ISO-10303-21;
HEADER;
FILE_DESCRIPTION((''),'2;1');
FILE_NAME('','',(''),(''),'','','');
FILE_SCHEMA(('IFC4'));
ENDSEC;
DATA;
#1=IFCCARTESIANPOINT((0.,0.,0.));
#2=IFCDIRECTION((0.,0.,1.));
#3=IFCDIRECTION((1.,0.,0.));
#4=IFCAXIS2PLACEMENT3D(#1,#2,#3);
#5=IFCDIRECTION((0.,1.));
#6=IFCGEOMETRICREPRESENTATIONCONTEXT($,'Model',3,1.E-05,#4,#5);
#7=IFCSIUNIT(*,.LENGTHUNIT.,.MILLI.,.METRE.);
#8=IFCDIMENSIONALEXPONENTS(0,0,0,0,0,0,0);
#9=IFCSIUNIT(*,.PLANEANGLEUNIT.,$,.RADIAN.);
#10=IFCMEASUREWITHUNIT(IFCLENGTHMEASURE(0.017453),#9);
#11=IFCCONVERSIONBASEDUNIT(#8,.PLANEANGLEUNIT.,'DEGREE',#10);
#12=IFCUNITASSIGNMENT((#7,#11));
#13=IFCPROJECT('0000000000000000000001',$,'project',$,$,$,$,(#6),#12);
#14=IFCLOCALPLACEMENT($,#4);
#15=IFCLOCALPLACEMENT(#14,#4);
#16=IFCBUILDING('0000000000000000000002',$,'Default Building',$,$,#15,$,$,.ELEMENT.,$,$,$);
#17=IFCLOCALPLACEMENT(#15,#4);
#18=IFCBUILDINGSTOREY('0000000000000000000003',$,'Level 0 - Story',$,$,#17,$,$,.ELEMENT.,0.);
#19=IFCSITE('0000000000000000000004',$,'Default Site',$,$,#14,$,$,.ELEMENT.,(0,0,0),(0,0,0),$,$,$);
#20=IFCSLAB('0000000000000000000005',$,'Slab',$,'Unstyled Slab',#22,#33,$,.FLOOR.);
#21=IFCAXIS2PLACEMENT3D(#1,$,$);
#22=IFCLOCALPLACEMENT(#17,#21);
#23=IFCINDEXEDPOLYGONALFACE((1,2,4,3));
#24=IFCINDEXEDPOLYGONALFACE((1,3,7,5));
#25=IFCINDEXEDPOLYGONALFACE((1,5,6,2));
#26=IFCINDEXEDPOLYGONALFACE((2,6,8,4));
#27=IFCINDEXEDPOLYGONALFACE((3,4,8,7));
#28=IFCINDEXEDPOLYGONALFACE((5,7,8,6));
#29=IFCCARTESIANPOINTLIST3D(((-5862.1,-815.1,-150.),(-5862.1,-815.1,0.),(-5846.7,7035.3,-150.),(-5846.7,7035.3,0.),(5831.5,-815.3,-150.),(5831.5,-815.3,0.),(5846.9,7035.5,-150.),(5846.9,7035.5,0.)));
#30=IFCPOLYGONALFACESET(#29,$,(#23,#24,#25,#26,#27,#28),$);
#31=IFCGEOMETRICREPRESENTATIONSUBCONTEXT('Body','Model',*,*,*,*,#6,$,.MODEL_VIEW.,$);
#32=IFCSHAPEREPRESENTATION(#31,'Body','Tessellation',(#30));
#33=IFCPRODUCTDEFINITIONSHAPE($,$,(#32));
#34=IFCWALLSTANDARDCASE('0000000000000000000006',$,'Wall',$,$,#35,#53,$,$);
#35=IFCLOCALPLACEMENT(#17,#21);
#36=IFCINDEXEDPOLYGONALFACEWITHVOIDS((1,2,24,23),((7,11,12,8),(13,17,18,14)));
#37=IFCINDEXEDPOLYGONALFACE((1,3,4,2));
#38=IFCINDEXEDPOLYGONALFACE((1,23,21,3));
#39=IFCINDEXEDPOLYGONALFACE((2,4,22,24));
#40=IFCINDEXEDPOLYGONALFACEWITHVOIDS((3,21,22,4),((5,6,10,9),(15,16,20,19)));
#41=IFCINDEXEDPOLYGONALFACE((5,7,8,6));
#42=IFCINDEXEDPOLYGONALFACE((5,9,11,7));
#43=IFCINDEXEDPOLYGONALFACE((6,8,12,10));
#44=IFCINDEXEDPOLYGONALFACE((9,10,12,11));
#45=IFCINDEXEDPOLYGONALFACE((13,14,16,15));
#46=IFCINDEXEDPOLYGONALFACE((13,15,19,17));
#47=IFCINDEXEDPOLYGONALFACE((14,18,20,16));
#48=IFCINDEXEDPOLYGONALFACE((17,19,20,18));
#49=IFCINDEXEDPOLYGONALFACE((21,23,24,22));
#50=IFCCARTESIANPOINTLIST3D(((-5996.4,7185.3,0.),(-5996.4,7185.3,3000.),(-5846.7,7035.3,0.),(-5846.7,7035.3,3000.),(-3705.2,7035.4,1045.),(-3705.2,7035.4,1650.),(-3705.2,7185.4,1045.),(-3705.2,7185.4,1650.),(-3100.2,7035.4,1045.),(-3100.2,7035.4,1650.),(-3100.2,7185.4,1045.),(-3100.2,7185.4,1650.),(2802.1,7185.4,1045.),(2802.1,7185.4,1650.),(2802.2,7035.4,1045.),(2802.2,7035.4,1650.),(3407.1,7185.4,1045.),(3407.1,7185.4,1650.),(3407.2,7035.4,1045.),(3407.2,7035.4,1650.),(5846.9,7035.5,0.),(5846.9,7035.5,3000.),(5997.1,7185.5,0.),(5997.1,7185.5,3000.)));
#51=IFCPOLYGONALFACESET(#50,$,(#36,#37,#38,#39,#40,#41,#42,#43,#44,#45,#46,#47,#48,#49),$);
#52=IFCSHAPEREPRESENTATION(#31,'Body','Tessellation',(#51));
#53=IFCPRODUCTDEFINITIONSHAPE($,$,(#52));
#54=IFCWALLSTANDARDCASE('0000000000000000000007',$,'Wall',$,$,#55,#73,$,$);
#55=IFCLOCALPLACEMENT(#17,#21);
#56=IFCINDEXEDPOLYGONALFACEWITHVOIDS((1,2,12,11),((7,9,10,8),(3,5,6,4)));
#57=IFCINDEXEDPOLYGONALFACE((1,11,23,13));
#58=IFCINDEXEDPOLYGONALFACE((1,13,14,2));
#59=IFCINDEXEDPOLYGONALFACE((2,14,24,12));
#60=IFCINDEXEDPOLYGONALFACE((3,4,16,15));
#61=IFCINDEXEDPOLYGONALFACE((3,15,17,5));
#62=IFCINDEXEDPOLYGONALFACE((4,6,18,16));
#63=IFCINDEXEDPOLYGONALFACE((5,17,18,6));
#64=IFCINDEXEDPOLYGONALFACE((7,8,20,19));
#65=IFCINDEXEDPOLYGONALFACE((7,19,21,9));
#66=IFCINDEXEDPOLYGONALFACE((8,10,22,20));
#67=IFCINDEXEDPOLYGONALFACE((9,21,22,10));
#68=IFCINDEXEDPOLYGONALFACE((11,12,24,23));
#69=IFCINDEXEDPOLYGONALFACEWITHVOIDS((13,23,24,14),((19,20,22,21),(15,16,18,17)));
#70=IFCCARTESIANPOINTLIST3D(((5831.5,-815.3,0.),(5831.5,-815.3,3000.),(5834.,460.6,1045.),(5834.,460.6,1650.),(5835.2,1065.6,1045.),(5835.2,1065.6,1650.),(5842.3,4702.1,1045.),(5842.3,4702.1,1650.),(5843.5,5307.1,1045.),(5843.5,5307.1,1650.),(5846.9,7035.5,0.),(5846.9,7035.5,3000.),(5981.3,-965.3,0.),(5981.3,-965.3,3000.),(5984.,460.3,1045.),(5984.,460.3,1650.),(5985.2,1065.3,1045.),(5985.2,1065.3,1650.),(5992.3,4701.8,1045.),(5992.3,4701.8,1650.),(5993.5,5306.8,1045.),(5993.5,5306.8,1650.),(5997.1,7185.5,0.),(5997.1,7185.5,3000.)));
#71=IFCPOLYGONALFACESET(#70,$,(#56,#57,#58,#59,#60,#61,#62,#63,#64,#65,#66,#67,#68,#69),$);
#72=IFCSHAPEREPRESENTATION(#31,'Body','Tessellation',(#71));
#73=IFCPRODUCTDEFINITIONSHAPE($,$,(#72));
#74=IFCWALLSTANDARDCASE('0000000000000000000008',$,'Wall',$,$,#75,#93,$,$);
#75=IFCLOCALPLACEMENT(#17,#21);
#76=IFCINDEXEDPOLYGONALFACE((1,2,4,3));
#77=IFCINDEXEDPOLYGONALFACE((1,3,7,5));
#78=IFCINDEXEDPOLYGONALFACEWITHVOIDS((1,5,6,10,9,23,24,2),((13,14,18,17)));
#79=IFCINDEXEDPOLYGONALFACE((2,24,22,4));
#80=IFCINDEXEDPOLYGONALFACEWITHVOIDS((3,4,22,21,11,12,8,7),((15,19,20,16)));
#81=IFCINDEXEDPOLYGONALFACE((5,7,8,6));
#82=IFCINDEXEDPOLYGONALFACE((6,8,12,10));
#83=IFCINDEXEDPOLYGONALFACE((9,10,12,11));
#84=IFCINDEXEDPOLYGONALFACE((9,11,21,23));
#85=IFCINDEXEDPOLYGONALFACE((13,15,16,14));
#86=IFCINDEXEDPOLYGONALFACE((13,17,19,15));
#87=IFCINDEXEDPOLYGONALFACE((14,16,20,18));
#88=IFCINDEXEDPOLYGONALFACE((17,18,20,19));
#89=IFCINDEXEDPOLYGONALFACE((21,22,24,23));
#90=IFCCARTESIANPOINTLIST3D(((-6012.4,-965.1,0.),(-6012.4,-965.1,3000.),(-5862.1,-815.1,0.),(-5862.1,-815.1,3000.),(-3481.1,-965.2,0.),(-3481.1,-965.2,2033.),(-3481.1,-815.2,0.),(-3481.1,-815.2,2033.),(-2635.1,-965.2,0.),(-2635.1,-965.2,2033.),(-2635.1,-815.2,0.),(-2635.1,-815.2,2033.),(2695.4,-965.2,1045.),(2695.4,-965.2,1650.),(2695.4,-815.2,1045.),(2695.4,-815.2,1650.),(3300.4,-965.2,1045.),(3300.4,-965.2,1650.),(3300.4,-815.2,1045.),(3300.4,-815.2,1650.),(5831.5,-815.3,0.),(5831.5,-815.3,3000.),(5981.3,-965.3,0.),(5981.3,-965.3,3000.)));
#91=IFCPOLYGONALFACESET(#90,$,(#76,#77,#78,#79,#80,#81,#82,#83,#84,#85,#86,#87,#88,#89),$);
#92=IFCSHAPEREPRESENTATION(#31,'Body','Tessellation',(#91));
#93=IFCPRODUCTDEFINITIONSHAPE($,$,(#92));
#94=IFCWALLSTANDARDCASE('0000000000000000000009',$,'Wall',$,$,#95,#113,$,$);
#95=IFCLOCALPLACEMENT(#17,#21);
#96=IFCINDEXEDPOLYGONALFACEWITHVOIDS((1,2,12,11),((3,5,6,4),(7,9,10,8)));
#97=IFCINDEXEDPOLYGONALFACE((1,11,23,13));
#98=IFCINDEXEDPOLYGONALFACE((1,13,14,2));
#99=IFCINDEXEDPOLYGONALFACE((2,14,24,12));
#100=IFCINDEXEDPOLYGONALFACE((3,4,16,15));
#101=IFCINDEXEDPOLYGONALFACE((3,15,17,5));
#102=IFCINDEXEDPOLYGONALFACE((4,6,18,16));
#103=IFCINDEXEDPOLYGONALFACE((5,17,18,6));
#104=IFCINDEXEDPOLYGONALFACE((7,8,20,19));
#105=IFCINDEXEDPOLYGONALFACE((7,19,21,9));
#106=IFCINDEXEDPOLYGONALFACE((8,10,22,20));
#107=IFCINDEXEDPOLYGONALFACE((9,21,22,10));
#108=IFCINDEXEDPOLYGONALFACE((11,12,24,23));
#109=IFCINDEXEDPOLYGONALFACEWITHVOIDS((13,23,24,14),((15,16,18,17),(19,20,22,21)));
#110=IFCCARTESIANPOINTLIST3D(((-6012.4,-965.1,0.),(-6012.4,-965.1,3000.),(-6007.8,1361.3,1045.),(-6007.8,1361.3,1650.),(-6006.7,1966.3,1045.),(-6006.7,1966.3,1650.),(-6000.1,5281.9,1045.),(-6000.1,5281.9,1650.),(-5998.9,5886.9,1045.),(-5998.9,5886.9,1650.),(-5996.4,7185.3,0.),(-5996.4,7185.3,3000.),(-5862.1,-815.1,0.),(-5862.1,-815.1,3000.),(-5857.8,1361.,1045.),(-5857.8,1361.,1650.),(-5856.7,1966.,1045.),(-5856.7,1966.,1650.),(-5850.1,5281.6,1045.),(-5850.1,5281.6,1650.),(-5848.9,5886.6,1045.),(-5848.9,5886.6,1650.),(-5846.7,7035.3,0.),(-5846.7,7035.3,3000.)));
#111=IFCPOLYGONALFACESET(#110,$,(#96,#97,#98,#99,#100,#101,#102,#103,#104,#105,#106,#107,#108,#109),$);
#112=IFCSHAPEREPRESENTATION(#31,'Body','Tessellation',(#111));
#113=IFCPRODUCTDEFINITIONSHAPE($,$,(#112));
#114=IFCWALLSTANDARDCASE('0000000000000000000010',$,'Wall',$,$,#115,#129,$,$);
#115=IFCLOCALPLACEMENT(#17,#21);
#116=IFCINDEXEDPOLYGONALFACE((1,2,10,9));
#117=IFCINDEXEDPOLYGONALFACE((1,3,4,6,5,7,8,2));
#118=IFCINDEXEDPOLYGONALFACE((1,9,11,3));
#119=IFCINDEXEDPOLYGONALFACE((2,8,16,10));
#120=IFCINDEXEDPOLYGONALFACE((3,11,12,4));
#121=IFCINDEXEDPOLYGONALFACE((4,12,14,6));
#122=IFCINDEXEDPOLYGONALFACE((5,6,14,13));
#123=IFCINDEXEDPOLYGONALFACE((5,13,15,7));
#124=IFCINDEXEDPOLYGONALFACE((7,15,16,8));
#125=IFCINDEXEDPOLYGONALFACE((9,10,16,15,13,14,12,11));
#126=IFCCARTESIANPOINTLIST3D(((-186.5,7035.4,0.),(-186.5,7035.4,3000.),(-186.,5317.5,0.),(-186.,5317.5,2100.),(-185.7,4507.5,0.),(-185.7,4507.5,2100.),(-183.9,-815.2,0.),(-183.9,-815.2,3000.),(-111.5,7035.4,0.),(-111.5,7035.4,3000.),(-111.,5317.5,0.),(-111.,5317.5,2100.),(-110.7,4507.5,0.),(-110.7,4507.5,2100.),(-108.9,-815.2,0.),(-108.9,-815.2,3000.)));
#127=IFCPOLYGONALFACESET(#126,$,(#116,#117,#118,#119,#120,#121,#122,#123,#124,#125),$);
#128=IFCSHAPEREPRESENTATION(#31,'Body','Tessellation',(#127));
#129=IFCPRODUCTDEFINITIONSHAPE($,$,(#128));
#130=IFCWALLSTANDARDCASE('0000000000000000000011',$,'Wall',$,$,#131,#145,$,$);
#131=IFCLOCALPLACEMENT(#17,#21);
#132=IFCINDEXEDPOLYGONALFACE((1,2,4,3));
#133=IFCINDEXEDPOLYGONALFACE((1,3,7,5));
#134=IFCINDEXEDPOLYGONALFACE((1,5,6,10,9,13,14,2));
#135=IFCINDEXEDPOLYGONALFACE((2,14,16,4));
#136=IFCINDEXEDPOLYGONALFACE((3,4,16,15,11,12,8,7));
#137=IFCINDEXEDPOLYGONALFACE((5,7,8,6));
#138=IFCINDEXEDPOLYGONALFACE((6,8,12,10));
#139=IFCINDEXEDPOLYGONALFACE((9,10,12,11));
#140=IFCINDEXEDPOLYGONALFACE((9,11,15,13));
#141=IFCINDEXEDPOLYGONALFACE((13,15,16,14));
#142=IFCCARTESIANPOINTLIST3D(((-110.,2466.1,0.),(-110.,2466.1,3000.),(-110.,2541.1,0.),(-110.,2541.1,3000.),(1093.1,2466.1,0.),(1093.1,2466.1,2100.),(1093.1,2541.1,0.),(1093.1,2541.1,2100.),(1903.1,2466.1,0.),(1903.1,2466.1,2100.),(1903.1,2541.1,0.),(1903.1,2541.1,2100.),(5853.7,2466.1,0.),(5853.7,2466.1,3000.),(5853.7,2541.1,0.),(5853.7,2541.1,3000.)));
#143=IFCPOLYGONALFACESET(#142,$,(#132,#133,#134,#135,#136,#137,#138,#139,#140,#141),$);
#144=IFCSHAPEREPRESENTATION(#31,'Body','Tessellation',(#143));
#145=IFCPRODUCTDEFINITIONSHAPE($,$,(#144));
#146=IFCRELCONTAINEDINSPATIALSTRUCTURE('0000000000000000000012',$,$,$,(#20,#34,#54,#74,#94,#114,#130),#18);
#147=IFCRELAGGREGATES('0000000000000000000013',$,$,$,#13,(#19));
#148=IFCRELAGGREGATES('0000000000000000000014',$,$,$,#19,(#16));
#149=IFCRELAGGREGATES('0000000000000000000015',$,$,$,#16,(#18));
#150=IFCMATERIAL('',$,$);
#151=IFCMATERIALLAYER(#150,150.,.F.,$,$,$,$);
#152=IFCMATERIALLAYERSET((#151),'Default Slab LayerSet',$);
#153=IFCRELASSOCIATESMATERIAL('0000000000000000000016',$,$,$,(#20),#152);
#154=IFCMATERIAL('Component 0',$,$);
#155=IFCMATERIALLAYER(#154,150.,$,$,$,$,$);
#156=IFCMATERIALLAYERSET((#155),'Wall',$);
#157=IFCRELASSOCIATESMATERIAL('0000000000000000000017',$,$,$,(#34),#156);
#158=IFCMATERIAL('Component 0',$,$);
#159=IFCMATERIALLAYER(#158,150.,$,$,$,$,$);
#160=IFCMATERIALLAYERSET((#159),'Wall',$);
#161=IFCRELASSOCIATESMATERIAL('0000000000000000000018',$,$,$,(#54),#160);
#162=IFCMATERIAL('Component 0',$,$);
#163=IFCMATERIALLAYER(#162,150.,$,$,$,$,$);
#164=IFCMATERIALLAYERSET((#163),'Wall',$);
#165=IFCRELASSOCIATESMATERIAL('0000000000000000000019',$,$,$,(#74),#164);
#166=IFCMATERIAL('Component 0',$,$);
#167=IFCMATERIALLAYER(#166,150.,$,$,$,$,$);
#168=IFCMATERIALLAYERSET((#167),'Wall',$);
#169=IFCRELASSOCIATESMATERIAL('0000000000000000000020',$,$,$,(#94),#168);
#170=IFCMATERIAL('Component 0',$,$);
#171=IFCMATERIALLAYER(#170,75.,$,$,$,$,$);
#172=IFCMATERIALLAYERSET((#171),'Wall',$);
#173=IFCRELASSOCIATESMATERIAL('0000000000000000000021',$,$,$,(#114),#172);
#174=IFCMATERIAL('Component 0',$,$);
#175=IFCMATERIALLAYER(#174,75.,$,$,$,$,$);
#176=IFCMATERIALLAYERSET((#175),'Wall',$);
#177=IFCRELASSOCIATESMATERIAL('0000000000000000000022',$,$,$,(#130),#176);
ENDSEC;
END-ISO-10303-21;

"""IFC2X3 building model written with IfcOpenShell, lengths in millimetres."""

from ifc_helpers import new_model, entity, si_unit, converted_unit, direction, frame, origin_with_axes, place, context, subcontext, project, spatial, polyline, outline, extrude, material, layer, layer_set, layer_usage, element, save


model = new_model("IFC2X3")

# Units and contexts
model_context = context("Model", 3, precision=1e-05, world=origin_with_axes(), true_north=direction((0.0, 1.0)))
body_context = subcontext(model_context, "Body", "Model", "MODEL_VIEW")
ifc_project = project(units=[si_unit("LENGTHUNIT", "METRE", prefix="MILLI"), converted_unit("PLANEANGLEUNIT", "DEGREE", entity("IfcLengthMeasure", 0.017453), si_unit("PLANEANGLEUNIT", "RADIAN"), dimensions=[0, 0, 0, 0, 0, 0, 0])], contexts=[model_context])

# Site, building, storey
site_placement = place(None, origin_with_axes())
site = spatial("IfcSite", under=ifc_project, at=site_placement, Name="Default Site", CompositionType="ELEMENT", RefLatitude=(0, 0, 0), RefLongitude=(0, 0, 0))
building_placement = place(site_placement, origin_with_axes())
building = spatial("IfcBuilding", under=site, at=building_placement, Name="Default Building", CompositionType="ELEMENT")
storey_placement = place(building_placement, origin_with_axes())
storey = spatial("IfcBuildingStorey", under=building, at=storey_placement, Name="Level 0 - Story", CompositionType="ELEMENT", Elevation=0.0)

# Slab
ifc_material_1 = material(Name="")
ifc_layer_1 = layer(ifc_material_1, 150.0, ventilated=False)
ifc_layer_set_1 = layer_set([ifc_layer_1], Name="Default Slab LayerSet")
ifc_layer_usage_1 = layer_usage(ifc_layer_set_1, "AXIS3", "NEGATIVE", 0.0)
slab_placement = place(storey_placement, origin_with_axes())
element("IfcSlab", 1, at=slab_placement, inside=storey, material=ifc_layer_usage_1, Name="Slab", ObjectType="Unstyled Slab", PredefinedType="FLOOR", context=body_context, shape_type="SweptSolid", body=[
    extrude(outline(polyline([(-15.5, 7850.5), (11678.1, 7850.8), (11693.5, 0.0), (0.0, 0.0), (-15.5, 7850.5)])), frame((-5846.7, 7035.3, -150.0), z_axis=(0.0, 0.0, -1.0), x_axis=(1.0, 0.000012, 0.0)), (0.0, 0.0, -1.0), 150.0),
])

# Walls, openings
ifc_material_2 = material(Name="Component 0")
ifc_layer_2 = layer(ifc_material_2, 150.0)
ifc_layer_set_2 = layer_set([ifc_layer_2], Name="Wall")
ifc_layer_usage_2 = layer_usage(ifc_layer_set_2, "AXIS2", "POSITIVE", -75.0)
wall_1_placement = place(storey_placement, frame((-5921.5, 7110.3, 0.0), z_axis=(0.0, 0.0, 1.0), x_axis=(1.0, 0.000012, 0.0)))
wall_1 = element("IfcWallStandardCase", 2, at=wall_1_placement, inside=storey, material=ifc_layer_usage_2, Name="Wall", context=body_context, shape_type="SweptSolid", body=[
    extrude(outline(polyline([(74.9, -75.0), (-74.9, 75.0), (11918.7, 75.0), (11768.4, -75.0), (74.9, -75.0)])), origin_with_axes(), (0.0, 0.0, 1.0), 3000.0),
])
opening_1_placement = place(wall_1_placement, frame((2216.3, 0.0, 1045.0), z_axis=(0.0, 1.0, 0.0), x_axis=(0.0, 0.0, 1.0)))
element("IfcOpeningElement", 3, at=opening_1_placement, cuts=wall_1, context=body_context, shape_type="SweptSolid", body=[
    extrude(outline(polyline([(0.0, 0.0), (605.0, 0.0), (605.0, 605.0), (0.0, 605.0), (0.0, 0.0)])), frame((0.0, 0.0, 150.0), z_axis=(0.0, 0.0, 1.0), x_axis=(1.0, 0.0, 0.0)), (0.0, 0.0, -1.0), 300.0),
])
opening_2_placement = place(wall_1_placement, frame((8723.7, 0.0, 1045.0), z_axis=(0.0, 1.0, 0.0), x_axis=(0.0, 0.0, 1.0)))
element("IfcOpeningElement", 4, at=opening_2_placement, cuts=wall_1, context=body_context, shape_type="SweptSolid", body=[
    extrude(outline(polyline([(0.0, 0.0), (605.0, 0.0), (605.0, 605.0), (0.0, 605.0), (0.0, 0.0)])), frame((0.0, 0.0, 150.0), z_axis=(0.0, 0.0, 1.0), x_axis=(1.0, 0.0, 0.0)), (0.0, 0.0, -1.0), 300.0),
])
ifc_material_3 = material(Name="Component 0")
ifc_layer_3 = layer(ifc_material_3, 150.0)
ifc_layer_set_3 = layer_set([ifc_layer_3], Name="Wall")
ifc_layer_usage_3 = layer_usage(ifc_layer_set_3, "AXIS2", "POSITIVE", -75.0)
wall_2_placement = place(storey_placement, frame((5922.0, 7110.5, 0.0), z_axis=(0.0, 0.0, 1.0), x_axis=(-0.00195, -0.999998, 0.0)))
wall_2 = element("IfcWallStandardCase", 5, at=wall_2_placement, inside=storey, material=ifc_layer_usage_3, Name="Wall", context=body_context, shape_type="SweptSolid", body=[
    extrude(outline(polyline([(75.1, -75.0), (-75.1, 75.0), (8075.6, 75.0), (7925.9, -75.0), (75.1, -75.0)])), origin_with_axes(), (0.0, 0.0, 1.0), 3000.0),
])
opening_3_placement = place(wall_2_placement, frame((1803.5, 0.0, 1045.0), z_axis=(0.0, 1.0, 0.0), x_axis=(0.0, 0.0, 1.0)))
element("IfcOpeningElement", 6, at=opening_3_placement, cuts=wall_2, context=body_context, shape_type="SweptSolid", body=[
    extrude(outline(polyline([(0.0, 0.0), (605.0, 0.0), (605.0, 605.0), (0.0, 605.0), (0.0, 0.0)])), frame((0.0, 0.0, 150.0), z_axis=(0.0, 0.0, 1.0), x_axis=(1.0, 0.0, 0.0)), (0.0, 0.0, -1.0), 300.0),
])
opening_4_placement = place(wall_2_placement, frame((6045.0, 0.0, 1045.0), z_axis=(0.0, 1.0, 0.0), x_axis=(0.0, 0.0, 1.0)))
element("IfcOpeningElement", 7, at=opening_4_placement, cuts=wall_2, context=body_context, shape_type="SweptSolid", body=[
    extrude(outline(polyline([(0.0, 0.0), (605.0, 0.0), (605.0, 605.0), (0.0, 605.0), (0.0, 0.0)])), frame((0.0, 0.0, 150.0), z_axis=(0.0, 0.0, 1.0), x_axis=(1.0, 0.0, 0.0)), (0.0, 0.0, -1.0), 300.0),
])
ifc_material_4 = material(Name="Component 0")
ifc_layer_4 = layer(ifc_material_4, 150.0)
ifc_layer_set_4 = layer_set([ifc_layer_4], Name="Wall")
ifc_layer_usage_4 = layer_usage(ifc_layer_set_4, "AXIS2", "POSITIVE", -75.0)
wall_3_placement = place(storey_placement, frame((5906.4, -890.3, 0.0), z_axis=(0.0, 0.0, 1.0), x_axis=(-1.0, 0.000012, 0.0)))
wall_3 = element("IfcWallStandardCase", 8, at=wall_3_placement, inside=storey, material=ifc_layer_usage_4, Name="Wall", context=body_context, shape_type="SweptSolid", body=[
    extrude(outline(polyline([(74.9, -75.0), (-74.9, 75.0), (11918.8, 75.0), (11768.5, -75.0), (74.9, -75.0)])), origin_with_axes(), (0.0, 0.0, 1.0), 3000.0),
])
opening_5_placement = place(wall_3_placement, frame((2606.0, 0.0, 1045.0), z_axis=(0.0, 1.0, 0.0), x_axis=(0.0, 0.0, 1.0)))
element("IfcOpeningElement", 9, at=opening_5_placement, cuts=wall_3, context=body_context, shape_type="SweptSolid", body=[
    extrude(outline(polyline([(0.0, 0.0), (605.0, 0.0), (605.0, 605.0), (0.0, 605.0), (0.0, 0.0)])), frame((0.0, 0.0, 150.0), z_axis=(0.0, 0.0, 1.0), x_axis=(1.0, 0.0, 0.0)), (0.0, 0.0, -1.0), 300.0),
])
opening_6_placement = place(wall_3_placement, frame((8541.5, 0.0, 0.0), z_axis=(0.0, 1.0, 0.0), x_axis=(0.0, 0.0, 1.0)))
element("IfcOpeningElement", 10, at=opening_6_placement, cuts=wall_3, context=body_context, shape_type="SweptSolid", body=[
    extrude(outline(polyline([(0.0, 0.0), (2033.0, 0.0), (2033.0, 846.0), (0.0, 846.0), (0.0, 0.0)])), frame((0.0, 0.0, 150.0), z_axis=(0.0, 0.0, 1.0), x_axis=(1.0, 0.0, 0.0)), (0.0, 0.0, -1.0), 300.0),
])
ifc_material_5 = material(Name="Component 0")
ifc_layer_5 = layer(ifc_material_5, 150.0)
ifc_layer_set_5 = layer_set([ifc_layer_5], Name="Wall")
ifc_layer_usage_5 = layer_usage(ifc_layer_set_5, "AXIS2", "POSITIVE", -75.0)
wall_4_placement = place(storey_placement, frame((-5921.5, 7110.3, 0.0), z_axis=(0.0, 0.0, 1.0), x_axis=(-0.001965, -0.999998, 0.0)))
wall_4 = element("IfcWallStandardCase", 11, at=wall_4_placement, inside=storey, material=ifc_layer_usage_5, Name="Wall", context=body_context, shape_type="SweptSolid", body=[
    extrude(outline(polyline([(-74.9, -75.0), (74.9, 75.0), (7925.3, 75.0), (8075.6, -75.0), (-74.9, -75.0)])), origin_with_axes(), (0.0, 0.0, 1.0), 3000.0),
])
opening_7_placement = place(wall_4_placement, frame((1828.6, 0.0, 1045.0), z_axis=(0.0, -1.0, 0.0), x_axis=(0.0, 0.0, 1.0)))
element("IfcOpeningElement", 12, at=opening_7_placement, cuts=wall_4, context=body_context, shape_type="SweptSolid", body=[
    extrude(outline(polyline([(0.0, 0.0), (605.0, 0.0), (605.0, 605.0), (0.0, 605.0), (0.0, 0.0)])), frame((0.0, 0.0, 150.0), z_axis=(0.0, 0.0, 1.0), x_axis=(1.0, 0.0, 0.0)), (0.0, 0.0, -1.0), 300.0),
])
opening_8_placement = place(wall_4_placement, frame((5749.2, 0.0, 1045.0), z_axis=(0.0, -1.0, 0.0), x_axis=(0.0, 0.0, 1.0)))
element("IfcOpeningElement", 13, at=opening_8_placement, cuts=wall_4, context=body_context, shape_type="SweptSolid", body=[
    extrude(outline(polyline([(0.0, 0.0), (605.0, 0.0), (605.0, 605.0), (0.0, 605.0), (0.0, 0.0)])), frame((0.0, 0.0, 150.0), z_axis=(0.0, 0.0, 1.0), x_axis=(1.0, 0.0, 0.0)), (0.0, 0.0, -1.0), 300.0),
])

# Walls, openings
ifc_material_6 = material(Name="Component 0")
ifc_layer_6 = layer(ifc_material_6, 75.0)
ifc_layer_set_6 = layer_set([ifc_layer_6], Name="Wall")
ifc_layer_usage_6 = layer_usage(ifc_layer_set_6, "AXIS2", "POSITIVE", -37.5)
wall_5_placement = place(storey_placement, frame((-149.0, 7035.4, 0.0), z_axis=(0.0, 0.0, 1.0), x_axis=(0.000332, -1.0, 0.0)))
wall_5 = element("IfcWallStandardCase", 14, at=wall_5_placement, inside=storey, material=ifc_layer_usage_6, Name="Wall", context=body_context, shape_type="SweptSolid", body=[
    extrude(outline(polyline([(0.0, -37.5), (0.0, 37.5), (7850.6, 37.5), (7850.6, -37.5), (0.0, -37.5)])), origin_with_axes(), (0.0, 0.0, 1.0), 3000.0),
])
opening_9_placement = place(wall_5_placement, frame((1717.9, 0.0, 0.0), z_axis=(0.0, 1.0, 0.0), x_axis=(0.0, 0.0, 1.0)))
element("IfcOpeningElement", 15, at=opening_9_placement, cuts=wall_5, context=body_context, shape_type="SweptSolid", body=[
    extrude(outline(polyline([(0.0, 0.0), (2100.0, 0.0), (2100.0, 810.0), (0.0, 810.0), (0.0, 0.0)])), frame((0.0, 0.0, 75.0), z_axis=(0.0, 0.0, 1.0), x_axis=(1.0, 0.0, 0.0)), (0.0, 0.0, -1.0), 150.0),
])
ifc_material_7 = material(Name="Component 0")
ifc_layer_7 = layer(ifc_material_7, 75.0)
ifc_layer_set_7 = layer_set([ifc_layer_7], Name="Wall")
ifc_layer_usage_7 = layer_usage(ifc_layer_set_7, "AXIS2", "POSITIVE", -37.5)
wall_6_placement = place(storey_placement, frame((-147.5, 2503.6, 0.0), z_axis=(0.0, 0.0, 1.0), x_axis=(1.0, 0.0, 0.0)))
wall_6 = element("IfcWallStandardCase", 16, at=wall_6_placement, inside=storey, material=ifc_layer_usage_7, Name="Wall", context=body_context, shape_type="SweptSolid", body=[
    extrude(outline(polyline([(37.5, -37.5), (37.5, 37.5), (6001.2, 37.5), (6001.2, -37.5), (37.5, -37.5)])), origin_with_axes(), (0.0, 0.0, 1.0), 3000.0),
])
opening_10_placement = place(wall_6_placement, frame((1240.7, 0.0, 0.0), z_axis=(0.0, 1.0, 0.0), x_axis=(0.0, 0.0, 1.0)))
element("IfcOpeningElement", 17, at=opening_10_placement, cuts=wall_6, context=body_context, shape_type="SweptSolid", body=[
    extrude(outline(polyline([(0.0, 0.0), (2100.0, 0.0), (2100.0, 810.0), (0.0, 810.0), (0.0, 0.0)])), frame((0.0, 0.0, 75.0), z_axis=(0.0, 0.0, 1.0), x_axis=(1.0, 0.0, 0.0)), (0.0, 0.0, -1.0), 150.0),
])

save(model, "model.ifc")
